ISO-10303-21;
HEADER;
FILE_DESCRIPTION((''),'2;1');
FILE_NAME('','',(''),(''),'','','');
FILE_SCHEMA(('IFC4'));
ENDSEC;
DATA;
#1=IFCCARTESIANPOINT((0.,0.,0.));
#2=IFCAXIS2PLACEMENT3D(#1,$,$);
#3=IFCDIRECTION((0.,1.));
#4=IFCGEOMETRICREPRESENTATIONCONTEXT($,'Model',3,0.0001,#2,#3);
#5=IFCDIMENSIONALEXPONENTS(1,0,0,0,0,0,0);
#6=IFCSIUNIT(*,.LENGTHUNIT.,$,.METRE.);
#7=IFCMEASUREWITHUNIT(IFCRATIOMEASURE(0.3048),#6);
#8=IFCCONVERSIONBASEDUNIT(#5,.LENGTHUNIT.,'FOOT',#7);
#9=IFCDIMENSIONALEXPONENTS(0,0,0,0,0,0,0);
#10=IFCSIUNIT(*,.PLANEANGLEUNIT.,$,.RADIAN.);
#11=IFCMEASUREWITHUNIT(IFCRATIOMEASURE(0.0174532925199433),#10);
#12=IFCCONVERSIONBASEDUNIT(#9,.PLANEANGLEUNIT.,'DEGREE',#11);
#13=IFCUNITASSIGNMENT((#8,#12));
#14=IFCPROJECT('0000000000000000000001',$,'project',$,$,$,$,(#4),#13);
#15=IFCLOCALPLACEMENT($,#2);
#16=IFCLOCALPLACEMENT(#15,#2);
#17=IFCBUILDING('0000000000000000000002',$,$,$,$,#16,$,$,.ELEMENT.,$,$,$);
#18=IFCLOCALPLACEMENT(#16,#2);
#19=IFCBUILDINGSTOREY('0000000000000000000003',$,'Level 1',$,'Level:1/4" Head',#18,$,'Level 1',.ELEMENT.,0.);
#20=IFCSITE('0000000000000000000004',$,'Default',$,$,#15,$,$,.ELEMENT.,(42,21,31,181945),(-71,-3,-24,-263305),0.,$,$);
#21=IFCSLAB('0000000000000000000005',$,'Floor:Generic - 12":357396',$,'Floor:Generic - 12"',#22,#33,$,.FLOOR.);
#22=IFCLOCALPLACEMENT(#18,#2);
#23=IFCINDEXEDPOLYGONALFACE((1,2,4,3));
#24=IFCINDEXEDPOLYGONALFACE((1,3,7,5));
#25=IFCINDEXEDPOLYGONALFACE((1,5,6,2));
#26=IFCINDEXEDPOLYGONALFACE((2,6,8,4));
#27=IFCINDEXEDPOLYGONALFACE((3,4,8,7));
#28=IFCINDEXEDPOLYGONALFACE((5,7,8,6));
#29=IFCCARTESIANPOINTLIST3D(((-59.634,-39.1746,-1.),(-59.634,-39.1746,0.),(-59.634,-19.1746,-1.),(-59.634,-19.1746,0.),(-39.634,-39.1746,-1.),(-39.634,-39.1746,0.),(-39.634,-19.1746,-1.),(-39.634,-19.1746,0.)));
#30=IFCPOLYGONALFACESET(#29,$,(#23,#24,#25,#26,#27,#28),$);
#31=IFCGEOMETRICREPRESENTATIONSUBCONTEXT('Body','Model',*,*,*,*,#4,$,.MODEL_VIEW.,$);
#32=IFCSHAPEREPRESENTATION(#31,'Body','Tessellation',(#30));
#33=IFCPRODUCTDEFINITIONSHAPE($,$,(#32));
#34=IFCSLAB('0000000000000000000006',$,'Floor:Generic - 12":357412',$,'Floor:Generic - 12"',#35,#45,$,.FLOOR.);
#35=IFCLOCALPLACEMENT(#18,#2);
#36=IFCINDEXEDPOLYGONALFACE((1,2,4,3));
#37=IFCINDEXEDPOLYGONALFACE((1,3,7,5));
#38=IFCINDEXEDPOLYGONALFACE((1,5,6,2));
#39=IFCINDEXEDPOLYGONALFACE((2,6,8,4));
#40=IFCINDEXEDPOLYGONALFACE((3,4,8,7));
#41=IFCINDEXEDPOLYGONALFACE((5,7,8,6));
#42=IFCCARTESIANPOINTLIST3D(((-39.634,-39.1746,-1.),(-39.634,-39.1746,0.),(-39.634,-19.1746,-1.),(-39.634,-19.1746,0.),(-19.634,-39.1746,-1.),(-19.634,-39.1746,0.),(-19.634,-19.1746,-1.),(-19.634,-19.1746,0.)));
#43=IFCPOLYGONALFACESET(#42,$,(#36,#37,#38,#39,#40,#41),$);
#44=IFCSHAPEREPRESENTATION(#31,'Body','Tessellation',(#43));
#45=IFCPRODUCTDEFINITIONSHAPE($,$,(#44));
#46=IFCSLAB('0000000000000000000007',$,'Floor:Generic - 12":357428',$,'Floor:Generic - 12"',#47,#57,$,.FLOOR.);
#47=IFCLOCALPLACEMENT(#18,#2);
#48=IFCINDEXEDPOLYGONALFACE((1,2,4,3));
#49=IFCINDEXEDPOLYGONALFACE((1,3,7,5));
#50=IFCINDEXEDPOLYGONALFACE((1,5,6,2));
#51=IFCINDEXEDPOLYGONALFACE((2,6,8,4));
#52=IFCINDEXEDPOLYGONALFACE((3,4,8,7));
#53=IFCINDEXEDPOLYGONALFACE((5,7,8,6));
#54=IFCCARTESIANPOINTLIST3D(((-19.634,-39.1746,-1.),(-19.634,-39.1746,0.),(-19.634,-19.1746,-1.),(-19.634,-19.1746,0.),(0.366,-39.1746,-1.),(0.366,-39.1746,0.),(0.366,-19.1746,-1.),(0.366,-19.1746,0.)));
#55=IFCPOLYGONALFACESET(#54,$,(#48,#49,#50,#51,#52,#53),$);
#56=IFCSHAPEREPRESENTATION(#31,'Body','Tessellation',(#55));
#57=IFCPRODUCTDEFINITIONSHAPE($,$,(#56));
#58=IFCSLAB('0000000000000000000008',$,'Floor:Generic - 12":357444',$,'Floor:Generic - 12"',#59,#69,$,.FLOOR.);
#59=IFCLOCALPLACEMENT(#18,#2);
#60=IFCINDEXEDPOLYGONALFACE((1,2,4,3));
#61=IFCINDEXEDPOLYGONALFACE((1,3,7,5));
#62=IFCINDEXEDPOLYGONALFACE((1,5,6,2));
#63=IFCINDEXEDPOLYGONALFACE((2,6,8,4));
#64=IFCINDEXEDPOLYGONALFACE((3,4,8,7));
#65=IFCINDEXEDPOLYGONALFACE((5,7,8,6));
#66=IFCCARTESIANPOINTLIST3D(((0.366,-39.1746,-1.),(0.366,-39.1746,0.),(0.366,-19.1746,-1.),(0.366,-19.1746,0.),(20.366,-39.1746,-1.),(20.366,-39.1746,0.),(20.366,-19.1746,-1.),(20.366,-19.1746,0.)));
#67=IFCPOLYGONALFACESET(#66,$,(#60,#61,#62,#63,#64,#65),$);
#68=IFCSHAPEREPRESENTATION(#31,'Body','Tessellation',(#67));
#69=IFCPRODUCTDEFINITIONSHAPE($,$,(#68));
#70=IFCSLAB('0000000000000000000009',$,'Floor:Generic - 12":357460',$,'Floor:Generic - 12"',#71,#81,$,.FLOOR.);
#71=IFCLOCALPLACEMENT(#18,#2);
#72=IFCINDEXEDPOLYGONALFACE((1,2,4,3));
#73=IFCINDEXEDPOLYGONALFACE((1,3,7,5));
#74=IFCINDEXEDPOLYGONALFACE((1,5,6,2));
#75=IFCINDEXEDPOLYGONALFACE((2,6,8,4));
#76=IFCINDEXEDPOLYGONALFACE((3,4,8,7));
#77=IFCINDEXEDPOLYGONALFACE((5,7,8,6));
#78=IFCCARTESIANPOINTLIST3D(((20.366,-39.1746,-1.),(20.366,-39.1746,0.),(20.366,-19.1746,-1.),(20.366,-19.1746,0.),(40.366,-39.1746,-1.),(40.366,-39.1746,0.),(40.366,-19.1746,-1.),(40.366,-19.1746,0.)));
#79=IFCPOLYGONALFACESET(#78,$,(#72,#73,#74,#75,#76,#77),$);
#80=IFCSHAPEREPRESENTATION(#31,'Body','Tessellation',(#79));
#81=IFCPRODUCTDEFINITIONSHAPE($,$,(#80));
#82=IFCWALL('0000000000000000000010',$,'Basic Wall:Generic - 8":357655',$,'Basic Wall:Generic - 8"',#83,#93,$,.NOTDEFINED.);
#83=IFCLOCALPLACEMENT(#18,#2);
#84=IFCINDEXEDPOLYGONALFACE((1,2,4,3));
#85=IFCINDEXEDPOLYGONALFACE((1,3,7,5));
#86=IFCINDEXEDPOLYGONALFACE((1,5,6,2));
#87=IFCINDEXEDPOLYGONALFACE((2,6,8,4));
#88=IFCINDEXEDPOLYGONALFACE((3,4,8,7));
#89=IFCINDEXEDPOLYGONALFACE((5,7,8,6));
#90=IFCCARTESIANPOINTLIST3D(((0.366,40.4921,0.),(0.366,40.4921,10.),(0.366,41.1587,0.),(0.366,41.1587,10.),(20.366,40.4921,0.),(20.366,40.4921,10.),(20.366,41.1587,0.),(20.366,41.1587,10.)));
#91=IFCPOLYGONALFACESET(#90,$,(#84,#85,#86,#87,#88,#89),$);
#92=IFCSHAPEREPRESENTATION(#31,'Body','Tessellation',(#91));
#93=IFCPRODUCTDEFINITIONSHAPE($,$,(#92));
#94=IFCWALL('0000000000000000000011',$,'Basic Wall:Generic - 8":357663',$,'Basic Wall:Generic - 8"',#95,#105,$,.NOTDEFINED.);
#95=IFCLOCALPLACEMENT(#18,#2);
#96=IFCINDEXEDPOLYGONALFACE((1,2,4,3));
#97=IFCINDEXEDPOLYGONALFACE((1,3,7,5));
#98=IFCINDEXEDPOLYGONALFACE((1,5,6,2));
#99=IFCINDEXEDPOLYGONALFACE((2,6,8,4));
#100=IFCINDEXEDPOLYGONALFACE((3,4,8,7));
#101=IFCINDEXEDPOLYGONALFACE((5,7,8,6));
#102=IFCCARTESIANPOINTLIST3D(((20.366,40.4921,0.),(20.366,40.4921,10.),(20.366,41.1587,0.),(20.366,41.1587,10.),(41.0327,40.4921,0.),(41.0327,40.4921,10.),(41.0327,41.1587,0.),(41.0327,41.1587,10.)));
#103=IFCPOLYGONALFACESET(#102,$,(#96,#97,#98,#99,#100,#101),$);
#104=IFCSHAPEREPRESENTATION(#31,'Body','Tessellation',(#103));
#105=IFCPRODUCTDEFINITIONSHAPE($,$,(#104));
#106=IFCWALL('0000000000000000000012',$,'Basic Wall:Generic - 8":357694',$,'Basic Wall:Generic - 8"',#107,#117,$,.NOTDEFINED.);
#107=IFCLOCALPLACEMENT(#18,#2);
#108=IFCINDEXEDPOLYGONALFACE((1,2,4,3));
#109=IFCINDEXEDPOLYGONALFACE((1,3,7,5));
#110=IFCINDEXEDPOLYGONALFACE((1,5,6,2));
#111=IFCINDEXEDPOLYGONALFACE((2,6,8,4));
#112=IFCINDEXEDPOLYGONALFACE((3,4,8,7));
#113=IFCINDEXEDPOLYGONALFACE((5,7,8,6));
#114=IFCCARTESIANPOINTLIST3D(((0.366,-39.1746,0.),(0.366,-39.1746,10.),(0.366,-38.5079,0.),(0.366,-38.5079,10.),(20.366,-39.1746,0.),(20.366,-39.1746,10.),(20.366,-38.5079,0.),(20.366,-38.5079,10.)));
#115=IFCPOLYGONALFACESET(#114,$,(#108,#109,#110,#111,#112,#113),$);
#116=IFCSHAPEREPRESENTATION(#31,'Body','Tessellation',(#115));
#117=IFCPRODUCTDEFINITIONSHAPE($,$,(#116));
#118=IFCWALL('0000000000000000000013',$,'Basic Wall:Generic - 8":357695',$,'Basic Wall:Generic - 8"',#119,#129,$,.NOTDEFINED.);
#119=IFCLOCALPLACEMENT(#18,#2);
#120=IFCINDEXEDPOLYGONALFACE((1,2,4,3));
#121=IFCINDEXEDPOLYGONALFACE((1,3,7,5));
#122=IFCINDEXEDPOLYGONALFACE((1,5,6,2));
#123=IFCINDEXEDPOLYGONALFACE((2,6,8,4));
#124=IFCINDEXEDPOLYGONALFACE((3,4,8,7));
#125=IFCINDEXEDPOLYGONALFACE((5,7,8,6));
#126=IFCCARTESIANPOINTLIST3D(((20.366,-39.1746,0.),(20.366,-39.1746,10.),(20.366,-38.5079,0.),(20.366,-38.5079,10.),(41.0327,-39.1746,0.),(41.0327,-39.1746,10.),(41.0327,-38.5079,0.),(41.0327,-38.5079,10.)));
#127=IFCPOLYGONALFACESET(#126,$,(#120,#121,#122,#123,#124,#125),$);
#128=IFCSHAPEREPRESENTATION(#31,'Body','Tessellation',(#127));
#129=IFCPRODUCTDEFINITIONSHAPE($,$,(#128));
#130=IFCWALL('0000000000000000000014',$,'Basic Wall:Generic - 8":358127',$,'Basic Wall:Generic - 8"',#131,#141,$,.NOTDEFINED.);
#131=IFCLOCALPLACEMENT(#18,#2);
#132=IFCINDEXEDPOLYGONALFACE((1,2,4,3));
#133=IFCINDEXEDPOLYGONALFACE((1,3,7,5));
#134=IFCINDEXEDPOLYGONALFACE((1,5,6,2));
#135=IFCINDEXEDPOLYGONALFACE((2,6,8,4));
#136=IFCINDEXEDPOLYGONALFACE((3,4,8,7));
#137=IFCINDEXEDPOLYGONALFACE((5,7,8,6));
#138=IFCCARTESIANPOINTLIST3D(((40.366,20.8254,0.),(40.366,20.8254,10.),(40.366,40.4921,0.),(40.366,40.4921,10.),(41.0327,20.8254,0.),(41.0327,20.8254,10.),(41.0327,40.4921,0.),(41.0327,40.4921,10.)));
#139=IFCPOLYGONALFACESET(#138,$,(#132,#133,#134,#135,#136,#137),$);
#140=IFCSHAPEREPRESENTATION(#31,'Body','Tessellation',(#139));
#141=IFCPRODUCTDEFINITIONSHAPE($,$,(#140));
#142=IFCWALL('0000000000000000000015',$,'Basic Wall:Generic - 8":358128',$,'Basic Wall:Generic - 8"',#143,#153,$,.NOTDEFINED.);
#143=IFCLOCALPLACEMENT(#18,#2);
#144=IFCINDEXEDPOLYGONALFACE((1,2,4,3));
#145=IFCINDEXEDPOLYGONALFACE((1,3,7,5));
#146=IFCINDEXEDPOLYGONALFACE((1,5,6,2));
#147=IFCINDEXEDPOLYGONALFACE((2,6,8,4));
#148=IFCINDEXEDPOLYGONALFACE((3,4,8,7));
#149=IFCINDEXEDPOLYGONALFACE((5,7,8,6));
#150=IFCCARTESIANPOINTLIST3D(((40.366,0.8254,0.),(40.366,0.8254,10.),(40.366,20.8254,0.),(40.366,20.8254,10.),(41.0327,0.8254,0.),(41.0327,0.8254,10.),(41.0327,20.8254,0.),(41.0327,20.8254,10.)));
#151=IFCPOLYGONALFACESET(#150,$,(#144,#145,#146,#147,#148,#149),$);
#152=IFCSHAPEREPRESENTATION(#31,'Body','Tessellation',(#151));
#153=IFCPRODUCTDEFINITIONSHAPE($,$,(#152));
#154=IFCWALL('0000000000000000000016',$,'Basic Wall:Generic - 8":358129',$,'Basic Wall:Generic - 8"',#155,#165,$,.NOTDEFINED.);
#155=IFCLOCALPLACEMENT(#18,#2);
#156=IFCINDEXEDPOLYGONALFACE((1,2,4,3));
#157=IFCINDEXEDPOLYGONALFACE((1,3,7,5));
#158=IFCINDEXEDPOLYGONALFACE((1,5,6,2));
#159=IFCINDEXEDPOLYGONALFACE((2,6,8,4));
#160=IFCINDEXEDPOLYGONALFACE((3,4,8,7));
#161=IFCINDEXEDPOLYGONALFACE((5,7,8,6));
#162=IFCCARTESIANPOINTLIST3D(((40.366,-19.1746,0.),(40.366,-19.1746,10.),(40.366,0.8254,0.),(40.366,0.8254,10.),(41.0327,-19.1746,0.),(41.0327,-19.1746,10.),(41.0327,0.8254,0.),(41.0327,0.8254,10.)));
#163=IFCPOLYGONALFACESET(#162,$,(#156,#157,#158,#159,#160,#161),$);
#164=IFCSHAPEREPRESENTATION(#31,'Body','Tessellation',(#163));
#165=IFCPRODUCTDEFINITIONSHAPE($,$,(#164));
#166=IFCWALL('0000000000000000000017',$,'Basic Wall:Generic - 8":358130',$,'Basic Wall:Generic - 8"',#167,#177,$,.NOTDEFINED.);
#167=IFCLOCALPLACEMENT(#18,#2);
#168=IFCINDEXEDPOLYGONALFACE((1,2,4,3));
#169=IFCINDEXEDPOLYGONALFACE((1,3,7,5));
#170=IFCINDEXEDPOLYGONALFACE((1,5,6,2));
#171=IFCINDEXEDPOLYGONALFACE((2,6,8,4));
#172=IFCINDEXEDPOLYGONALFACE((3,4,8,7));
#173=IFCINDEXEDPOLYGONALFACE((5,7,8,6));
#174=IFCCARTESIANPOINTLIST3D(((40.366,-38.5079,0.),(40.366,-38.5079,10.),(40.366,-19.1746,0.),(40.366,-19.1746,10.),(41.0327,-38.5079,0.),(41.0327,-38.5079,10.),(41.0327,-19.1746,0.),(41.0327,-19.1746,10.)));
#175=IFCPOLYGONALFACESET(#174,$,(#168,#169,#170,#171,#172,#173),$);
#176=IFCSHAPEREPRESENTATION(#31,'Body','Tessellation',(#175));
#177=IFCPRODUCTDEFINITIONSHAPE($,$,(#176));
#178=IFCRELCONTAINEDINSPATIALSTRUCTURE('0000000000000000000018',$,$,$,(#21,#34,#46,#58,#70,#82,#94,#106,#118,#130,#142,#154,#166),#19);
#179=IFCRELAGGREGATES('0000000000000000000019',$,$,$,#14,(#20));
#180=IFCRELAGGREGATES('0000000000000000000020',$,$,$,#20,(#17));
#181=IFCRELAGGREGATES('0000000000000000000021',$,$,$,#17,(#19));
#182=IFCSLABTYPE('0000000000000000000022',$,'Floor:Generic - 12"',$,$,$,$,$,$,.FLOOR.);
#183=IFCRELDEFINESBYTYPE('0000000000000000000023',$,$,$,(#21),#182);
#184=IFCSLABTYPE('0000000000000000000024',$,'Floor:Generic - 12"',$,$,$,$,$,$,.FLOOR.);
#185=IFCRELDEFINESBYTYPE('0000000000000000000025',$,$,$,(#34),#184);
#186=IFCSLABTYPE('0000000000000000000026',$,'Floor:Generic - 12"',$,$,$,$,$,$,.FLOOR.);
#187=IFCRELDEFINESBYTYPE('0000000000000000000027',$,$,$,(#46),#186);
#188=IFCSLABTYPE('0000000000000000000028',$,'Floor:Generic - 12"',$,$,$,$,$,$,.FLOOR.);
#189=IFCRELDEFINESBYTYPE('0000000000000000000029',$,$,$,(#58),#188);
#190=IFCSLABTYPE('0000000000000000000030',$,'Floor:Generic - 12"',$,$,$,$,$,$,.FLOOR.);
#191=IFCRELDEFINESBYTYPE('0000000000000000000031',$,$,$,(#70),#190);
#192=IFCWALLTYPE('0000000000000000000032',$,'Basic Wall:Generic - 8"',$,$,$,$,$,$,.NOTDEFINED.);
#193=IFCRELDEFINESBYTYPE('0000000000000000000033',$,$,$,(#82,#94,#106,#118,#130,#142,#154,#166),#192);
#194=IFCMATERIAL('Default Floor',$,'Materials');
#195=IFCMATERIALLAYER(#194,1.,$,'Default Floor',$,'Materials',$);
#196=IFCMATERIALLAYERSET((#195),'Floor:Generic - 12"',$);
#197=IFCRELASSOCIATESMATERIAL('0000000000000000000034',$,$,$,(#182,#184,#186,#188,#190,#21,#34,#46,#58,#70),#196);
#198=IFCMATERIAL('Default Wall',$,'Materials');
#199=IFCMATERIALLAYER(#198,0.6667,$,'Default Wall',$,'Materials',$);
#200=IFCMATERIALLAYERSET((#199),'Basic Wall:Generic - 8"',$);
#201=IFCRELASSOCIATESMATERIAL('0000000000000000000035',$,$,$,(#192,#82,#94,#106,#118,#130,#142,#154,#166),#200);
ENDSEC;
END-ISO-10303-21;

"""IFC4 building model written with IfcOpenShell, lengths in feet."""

from ifc_helpers import new_model, entity, si_unit, converted_unit, direction, frame, frame_2d, origin, origin_2d_with_axis, place, context, subcontext, project, spatial, rectangle, extrude, material, layer, layer_set, layer_usage, type_object, element, save


model = new_model("IFC4")

# Units and contexts
model_context = context("Model", 3, precision=0.0001, world=origin(), true_north=direction((0.0, 1.0)))
body_context = subcontext(model_context, "Body", "Model", "MODEL_VIEW")
ifc_project = project(units=[converted_unit("LENGTHUNIT", "FOOT", entity("IfcRatioMeasure", 0.3048), si_unit("LENGTHUNIT", "METRE"), dimensions=[1, 0, 0, 0, 0, 0, 0]), converted_unit("PLANEANGLEUNIT", "DEGREE", entity("IfcRatioMeasure", 0.0174532925199433), si_unit("PLANEANGLEUNIT", "RADIAN"), dimensions=[0, 0, 0, 0, 0, 0, 0])], contexts=[model_context])

# Site, building, storey
site_placement = place(None, origin())
site = spatial("IfcSite", under=ifc_project, at=site_placement, Name="Default", CompositionType="ELEMENT", RefLatitude=(42, 21, 31, 181945), RefLongitude=(-71, -3, -24, -263305), RefElevation=0.0)
building_placement = place(site_placement, origin())
building = spatial("IfcBuilding", under=site, at=building_placement, CompositionType="ELEMENT")
storey_placement = place(building_placement, origin())
storey = spatial("IfcBuildingStorey", under=building, at=storey_placement, Name="Level 1", ObjectType="Level:1/4\" Head", LongName="Level 1", CompositionType="ELEMENT", Elevation=0.0)

# Slabs
ifc_material_1 = material(Name="Default Floor", Category="Materials")
ifc_layer_1 = layer(ifc_material_1, 1.0, Name="Default Floor", Category="Materials")
ifc_layer_set_1 = layer_set([ifc_layer_1], Name="Floor:Generic - 12\"")
ifc_layer_usage_1 = layer_usage(ifc_layer_set_1, "AXIS3", "POSITIVE", 0.0)
slab_type_1 = type_object("IfcSlabType", Name="Floor:Generic - 12\"", PredefinedType="FLOOR", material=ifc_layer_set_1)
slab_1_placement = place(storey_placement, origin())
element("IfcSlab", 1, at=slab_1_placement, inside=storey, type_object=slab_type_1, material=ifc_layer_usage_1, Name="Floor:Generic - 12\":357396", ObjectType="Floor:Generic - 12\"", PredefinedType="FLOOR", context=body_context, shape_type="SweptSolid", body=[
    extrude(rectangle(XDim=20.0, YDim=20.0, at=frame_2d((0.0, 0.0), x_axis=(1.0, 0.0))), frame((-49.634, -29.1746, 0.0), z_axis=(0.0, 0.0, -1.0), x_axis=(0.0, 1.0, 0.0)), (0.0, 0.0, 1.0), 1.0),
])
ifc_layer_usage_2 = layer_usage(ifc_layer_set_1, "AXIS3", "POSITIVE", 0.0)
slab_type_2 = type_object("IfcSlabType", Name="Floor:Generic - 12\"", PredefinedType="FLOOR", material=ifc_layer_set_1)
slab_2_placement = place(storey_placement, origin())
element("IfcSlab", 2, at=slab_2_placement, inside=storey, type_object=slab_type_2, material=ifc_layer_usage_2, Name="Floor:Generic - 12\":357412", ObjectType="Floor:Generic - 12\"", PredefinedType="FLOOR", context=body_context, shape_type="SweptSolid", body=[
    extrude(rectangle(XDim=20.0, YDim=20.0, at=origin_2d_with_axis()), frame((-29.634, -29.1746, 0.0), z_axis=(0.0, 0.0, -1.0), x_axis=(0.0, 1.0, 0.0)), (0.0, 0.0, 1.0), 1.0),
])
ifc_layer_usage_3 = layer_usage(ifc_layer_set_1, "AXIS3", "POSITIVE", 0.0)
slab_type_3 = type_object("IfcSlabType", Name="Floor:Generic - 12\"", PredefinedType="FLOOR", material=ifc_layer_set_1)
slab_3_placement = place(storey_placement, origin())
element("IfcSlab", 3, at=slab_3_placement, inside=storey, type_object=slab_type_3, material=ifc_layer_usage_3, Name="Floor:Generic - 12\":357428", ObjectType="Floor:Generic - 12\"", PredefinedType="FLOOR", context=body_context, shape_type="SweptSolid", body=[
    extrude(rectangle(XDim=20.0, YDim=20.0, at=origin_2d_with_axis()), frame((-9.634, -29.1746, 0.0), z_axis=(0.0, 0.0, -1.0), x_axis=(0.0, 1.0, 0.0)), (0.0, 0.0, 1.0), 1.0),
])
ifc_layer_usage_4 = layer_usage(ifc_layer_set_1, "AXIS3", "POSITIVE", 0.0)
slab_type_4 = type_object("IfcSlabType", Name="Floor:Generic - 12\"", PredefinedType="FLOOR", material=ifc_layer_set_1)
slab_4_placement = place(storey_placement, origin())
element("IfcSlab", 4, at=slab_4_placement, inside=storey, type_object=slab_type_4, material=ifc_layer_usage_4, Name="Floor:Generic - 12\":357444", ObjectType="Floor:Generic - 12\"", PredefinedType="FLOOR", context=body_context, shape_type="SweptSolid", body=[
    extrude(rectangle(XDim=20.0, YDim=20.0, at=origin_2d_with_axis()), frame((10.366, -29.1746, 0.0), z_axis=(0.0, 0.0, -1.0), x_axis=(0.0, 1.0, 0.0)), (0.0, 0.0, 1.0), 1.0),
])
ifc_layer_usage_5 = layer_usage(ifc_layer_set_1, "AXIS3", "POSITIVE", 0.0)
slab_type_5 = type_object("IfcSlabType", Name="Floor:Generic - 12\"", PredefinedType="FLOOR", material=ifc_layer_set_1)
slab_5_placement = place(storey_placement, origin())
element("IfcSlab", 5, at=slab_5_placement, inside=storey, type_object=slab_type_5, material=ifc_layer_usage_5, Name="Floor:Generic - 12\":357460", ObjectType="Floor:Generic - 12\"", PredefinedType="FLOOR", context=body_context, shape_type="SweptSolid", body=[
    extrude(rectangle(XDim=20.0, YDim=20.0, at=frame_2d((0.0, 0.0), x_axis=(1.0, 0.0))), frame((30.366, -29.1746, 0.0), z_axis=(0.0, 0.0, -1.0), x_axis=(0.0, 1.0, 0.0)), (0.0, 0.0, 1.0), 1.0),
])

# Walls
ifc_material_2 = material(Name="Default Wall", Category="Materials")
ifc_layer_2 = layer(ifc_material_2, 0.6667, Name="Default Wall", Category="Materials")
ifc_layer_set_2 = layer_set([ifc_layer_2], Name="Basic Wall:Generic - 8\"")
ifc_layer_usage_6 = layer_usage(ifc_layer_set_2, "AXIS2", "NEGATIVE", 0.3333)
wall_type = type_object("IfcWallType", Name="Basic Wall:Generic - 8\"", PredefinedType="NOTDEFINED", material=ifc_layer_set_2)
wall_1_placement = place(storey_placement, frame((0.366, 40.8254, 0.0)))
element("IfcWall", 6, at=wall_1_placement, inside=storey, type_object=wall_type, material=ifc_layer_usage_6, Name="Basic Wall:Generic - 8\":357655", ObjectType="Basic Wall:Generic - 8\"", PredefinedType="NOTDEFINED", context=body_context, shape_type="SweptSolid", body=[
    extrude(rectangle(XDim=20.0, YDim=0.6667, at=frame_2d((10.0, 0.0), x_axis=(-1.0, 0.0))), origin(), (0.0, 0.0, 1.0), 10.0),
])
ifc_layer_usage_7 = layer_usage(ifc_layer_set_2, "AXIS2", "NEGATIVE", 0.3333)
wall_2_placement = place(storey_placement, frame((20.366, 40.8254, 0.0)))
element("IfcWall", 7, at=wall_2_placement, inside=storey, type_object=wall_type, material=ifc_layer_usage_7, Name="Basic Wall:Generic - 8\":357663", ObjectType="Basic Wall:Generic - 8\"", PredefinedType="NOTDEFINED", context=body_context, shape_type="SweptSolid", body=[
    extrude(rectangle(XDim=20.6667, YDim=0.6667, at=frame_2d((10.3333, 0.0), x_axis=(-1.0, 0.0))), origin(), (0.0, 0.0, 1.0), 10.0),
])
ifc_layer_usage_8 = layer_usage(ifc_layer_set_2, "AXIS2", "NEGATIVE", 0.3333)
wall_3_placement = place(storey_placement, frame((0.366, -38.8413, 0.0)))
element("IfcWall", 8, at=wall_3_placement, inside=storey, type_object=wall_type, material=ifc_layer_usage_8, Name="Basic Wall:Generic - 8\":357694", ObjectType="Basic Wall:Generic - 8\"", PredefinedType="NOTDEFINED", context=body_context, shape_type="SweptSolid", body=[
    extrude(rectangle(XDim=20.0, YDim=0.6667, at=frame_2d((10.0, 0.0), x_axis=(-1.0, 0.0))), origin(), (0.0, 0.0, 1.0), 10.0),
])
ifc_layer_usage_9 = layer_usage(ifc_layer_set_2, "AXIS2", "NEGATIVE", 0.3333)
wall_4_placement = place(storey_placement, frame((20.366, -38.8413, 0.0)))
element("IfcWall", 9, at=wall_4_placement, inside=storey, type_object=wall_type, material=ifc_layer_usage_9, Name="Basic Wall:Generic - 8\":357695", ObjectType="Basic Wall:Generic - 8\"", PredefinedType="NOTDEFINED", context=body_context, shape_type="SweptSolid", body=[
    extrude(rectangle(XDim=20.6667, YDim=0.6667, at=frame_2d((10.3333, 0.0), x_axis=(-1.0, 0.0))), origin(), (0.0, 0.0, 1.0), 10.0),
])
ifc_layer_usage_10 = layer_usage(ifc_layer_set_2, "AXIS2", "NEGATIVE", 0.3333)
wall_5_placement = place(storey_placement, frame((40.6993, 40.4921, 0.0), z_axis=(0.0, 0.0, 1.0), x_axis=(0.0, -1.0, 0.0)))
element("IfcWall", 10, at=wall_5_placement, inside=storey, type_object=wall_type, material=ifc_layer_usage_10, Name="Basic Wall:Generic - 8\":358127", ObjectType="Basic Wall:Generic - 8\"", PredefinedType="NOTDEFINED", context=body_context, shape_type="SweptSolid", body=[
    extrude(rectangle(XDim=19.6667, YDim=0.6667, at=frame_2d((9.8333, 0.0), x_axis=(-1.0, 0.0))), origin(), (0.0, 0.0, 1.0), 10.0),
])
ifc_layer_usage_11 = layer_usage(ifc_layer_set_2, "AXIS2", "NEGATIVE", 0.3333)
wall_6_placement = place(storey_placement, frame((40.6993, 20.8254, 0.0), z_axis=(0.0, 0.0, 1.0), x_axis=(0.0, -1.0, 0.0)))
element("IfcWall", 11, at=wall_6_placement, inside=storey, type_object=wall_type, material=ifc_layer_usage_11, Name="Basic Wall:Generic - 8\":358128", ObjectType="Basic Wall:Generic - 8\"", PredefinedType="NOTDEFINED", context=body_context, shape_type="SweptSolid", body=[
    extrude(rectangle(XDim=20.0, YDim=0.6667, at=frame_2d((10.0, 0.0), x_axis=(-1.0, 0.0))), origin(), (0.0, 0.0, 1.0), 10.0),
])
ifc_layer_usage_12 = layer_usage(ifc_layer_set_2, "AXIS2", "NEGATIVE", 0.3333)
wall_7_placement = place(storey_placement, frame((40.6993, 0.8254, 0.0), z_axis=(0.0, 0.0, 1.0), x_axis=(0.0, -1.0, 0.0)))
element("IfcWall", 12, at=wall_7_placement, inside=storey, type_object=wall_type, material=ifc_layer_usage_12, Name="Basic Wall:Generic - 8\":358129", ObjectType="Basic Wall:Generic - 8\"", PredefinedType="NOTDEFINED", context=body_context, shape_type="SweptSolid", body=[
    extrude(rectangle(XDim=20.0, YDim=0.6667, at=frame_2d((10.0, 0.0), x_axis=(-1.0, 0.0))), origin(), (0.0, 0.0, 1.0), 10.0),
])
ifc_layer_usage_13 = layer_usage(ifc_layer_set_2, "AXIS2", "NEGATIVE", 0.3333)
wall_8_placement = place(storey_placement, frame((40.6993, -19.1746, 0.0), z_axis=(0.0, 0.0, 1.0), x_axis=(0.0, -1.0, 0.0)))
element("IfcWall", 13, at=wall_8_placement, inside=storey, type_object=wall_type, material=ifc_layer_usage_13, Name="Basic Wall:Generic - 8\":358130", ObjectType="Basic Wall:Generic - 8\"", PredefinedType="NOTDEFINED", context=body_context, shape_type="SweptSolid", body=[
    extrude(rectangle(XDim=19.3333, YDim=0.6667, at=frame_2d((9.6667, 0.0), x_axis=(-1.0, 0.0))), origin(), (0.0, 0.0, 1.0), 10.0),
])

save(model, "model.ifc")
